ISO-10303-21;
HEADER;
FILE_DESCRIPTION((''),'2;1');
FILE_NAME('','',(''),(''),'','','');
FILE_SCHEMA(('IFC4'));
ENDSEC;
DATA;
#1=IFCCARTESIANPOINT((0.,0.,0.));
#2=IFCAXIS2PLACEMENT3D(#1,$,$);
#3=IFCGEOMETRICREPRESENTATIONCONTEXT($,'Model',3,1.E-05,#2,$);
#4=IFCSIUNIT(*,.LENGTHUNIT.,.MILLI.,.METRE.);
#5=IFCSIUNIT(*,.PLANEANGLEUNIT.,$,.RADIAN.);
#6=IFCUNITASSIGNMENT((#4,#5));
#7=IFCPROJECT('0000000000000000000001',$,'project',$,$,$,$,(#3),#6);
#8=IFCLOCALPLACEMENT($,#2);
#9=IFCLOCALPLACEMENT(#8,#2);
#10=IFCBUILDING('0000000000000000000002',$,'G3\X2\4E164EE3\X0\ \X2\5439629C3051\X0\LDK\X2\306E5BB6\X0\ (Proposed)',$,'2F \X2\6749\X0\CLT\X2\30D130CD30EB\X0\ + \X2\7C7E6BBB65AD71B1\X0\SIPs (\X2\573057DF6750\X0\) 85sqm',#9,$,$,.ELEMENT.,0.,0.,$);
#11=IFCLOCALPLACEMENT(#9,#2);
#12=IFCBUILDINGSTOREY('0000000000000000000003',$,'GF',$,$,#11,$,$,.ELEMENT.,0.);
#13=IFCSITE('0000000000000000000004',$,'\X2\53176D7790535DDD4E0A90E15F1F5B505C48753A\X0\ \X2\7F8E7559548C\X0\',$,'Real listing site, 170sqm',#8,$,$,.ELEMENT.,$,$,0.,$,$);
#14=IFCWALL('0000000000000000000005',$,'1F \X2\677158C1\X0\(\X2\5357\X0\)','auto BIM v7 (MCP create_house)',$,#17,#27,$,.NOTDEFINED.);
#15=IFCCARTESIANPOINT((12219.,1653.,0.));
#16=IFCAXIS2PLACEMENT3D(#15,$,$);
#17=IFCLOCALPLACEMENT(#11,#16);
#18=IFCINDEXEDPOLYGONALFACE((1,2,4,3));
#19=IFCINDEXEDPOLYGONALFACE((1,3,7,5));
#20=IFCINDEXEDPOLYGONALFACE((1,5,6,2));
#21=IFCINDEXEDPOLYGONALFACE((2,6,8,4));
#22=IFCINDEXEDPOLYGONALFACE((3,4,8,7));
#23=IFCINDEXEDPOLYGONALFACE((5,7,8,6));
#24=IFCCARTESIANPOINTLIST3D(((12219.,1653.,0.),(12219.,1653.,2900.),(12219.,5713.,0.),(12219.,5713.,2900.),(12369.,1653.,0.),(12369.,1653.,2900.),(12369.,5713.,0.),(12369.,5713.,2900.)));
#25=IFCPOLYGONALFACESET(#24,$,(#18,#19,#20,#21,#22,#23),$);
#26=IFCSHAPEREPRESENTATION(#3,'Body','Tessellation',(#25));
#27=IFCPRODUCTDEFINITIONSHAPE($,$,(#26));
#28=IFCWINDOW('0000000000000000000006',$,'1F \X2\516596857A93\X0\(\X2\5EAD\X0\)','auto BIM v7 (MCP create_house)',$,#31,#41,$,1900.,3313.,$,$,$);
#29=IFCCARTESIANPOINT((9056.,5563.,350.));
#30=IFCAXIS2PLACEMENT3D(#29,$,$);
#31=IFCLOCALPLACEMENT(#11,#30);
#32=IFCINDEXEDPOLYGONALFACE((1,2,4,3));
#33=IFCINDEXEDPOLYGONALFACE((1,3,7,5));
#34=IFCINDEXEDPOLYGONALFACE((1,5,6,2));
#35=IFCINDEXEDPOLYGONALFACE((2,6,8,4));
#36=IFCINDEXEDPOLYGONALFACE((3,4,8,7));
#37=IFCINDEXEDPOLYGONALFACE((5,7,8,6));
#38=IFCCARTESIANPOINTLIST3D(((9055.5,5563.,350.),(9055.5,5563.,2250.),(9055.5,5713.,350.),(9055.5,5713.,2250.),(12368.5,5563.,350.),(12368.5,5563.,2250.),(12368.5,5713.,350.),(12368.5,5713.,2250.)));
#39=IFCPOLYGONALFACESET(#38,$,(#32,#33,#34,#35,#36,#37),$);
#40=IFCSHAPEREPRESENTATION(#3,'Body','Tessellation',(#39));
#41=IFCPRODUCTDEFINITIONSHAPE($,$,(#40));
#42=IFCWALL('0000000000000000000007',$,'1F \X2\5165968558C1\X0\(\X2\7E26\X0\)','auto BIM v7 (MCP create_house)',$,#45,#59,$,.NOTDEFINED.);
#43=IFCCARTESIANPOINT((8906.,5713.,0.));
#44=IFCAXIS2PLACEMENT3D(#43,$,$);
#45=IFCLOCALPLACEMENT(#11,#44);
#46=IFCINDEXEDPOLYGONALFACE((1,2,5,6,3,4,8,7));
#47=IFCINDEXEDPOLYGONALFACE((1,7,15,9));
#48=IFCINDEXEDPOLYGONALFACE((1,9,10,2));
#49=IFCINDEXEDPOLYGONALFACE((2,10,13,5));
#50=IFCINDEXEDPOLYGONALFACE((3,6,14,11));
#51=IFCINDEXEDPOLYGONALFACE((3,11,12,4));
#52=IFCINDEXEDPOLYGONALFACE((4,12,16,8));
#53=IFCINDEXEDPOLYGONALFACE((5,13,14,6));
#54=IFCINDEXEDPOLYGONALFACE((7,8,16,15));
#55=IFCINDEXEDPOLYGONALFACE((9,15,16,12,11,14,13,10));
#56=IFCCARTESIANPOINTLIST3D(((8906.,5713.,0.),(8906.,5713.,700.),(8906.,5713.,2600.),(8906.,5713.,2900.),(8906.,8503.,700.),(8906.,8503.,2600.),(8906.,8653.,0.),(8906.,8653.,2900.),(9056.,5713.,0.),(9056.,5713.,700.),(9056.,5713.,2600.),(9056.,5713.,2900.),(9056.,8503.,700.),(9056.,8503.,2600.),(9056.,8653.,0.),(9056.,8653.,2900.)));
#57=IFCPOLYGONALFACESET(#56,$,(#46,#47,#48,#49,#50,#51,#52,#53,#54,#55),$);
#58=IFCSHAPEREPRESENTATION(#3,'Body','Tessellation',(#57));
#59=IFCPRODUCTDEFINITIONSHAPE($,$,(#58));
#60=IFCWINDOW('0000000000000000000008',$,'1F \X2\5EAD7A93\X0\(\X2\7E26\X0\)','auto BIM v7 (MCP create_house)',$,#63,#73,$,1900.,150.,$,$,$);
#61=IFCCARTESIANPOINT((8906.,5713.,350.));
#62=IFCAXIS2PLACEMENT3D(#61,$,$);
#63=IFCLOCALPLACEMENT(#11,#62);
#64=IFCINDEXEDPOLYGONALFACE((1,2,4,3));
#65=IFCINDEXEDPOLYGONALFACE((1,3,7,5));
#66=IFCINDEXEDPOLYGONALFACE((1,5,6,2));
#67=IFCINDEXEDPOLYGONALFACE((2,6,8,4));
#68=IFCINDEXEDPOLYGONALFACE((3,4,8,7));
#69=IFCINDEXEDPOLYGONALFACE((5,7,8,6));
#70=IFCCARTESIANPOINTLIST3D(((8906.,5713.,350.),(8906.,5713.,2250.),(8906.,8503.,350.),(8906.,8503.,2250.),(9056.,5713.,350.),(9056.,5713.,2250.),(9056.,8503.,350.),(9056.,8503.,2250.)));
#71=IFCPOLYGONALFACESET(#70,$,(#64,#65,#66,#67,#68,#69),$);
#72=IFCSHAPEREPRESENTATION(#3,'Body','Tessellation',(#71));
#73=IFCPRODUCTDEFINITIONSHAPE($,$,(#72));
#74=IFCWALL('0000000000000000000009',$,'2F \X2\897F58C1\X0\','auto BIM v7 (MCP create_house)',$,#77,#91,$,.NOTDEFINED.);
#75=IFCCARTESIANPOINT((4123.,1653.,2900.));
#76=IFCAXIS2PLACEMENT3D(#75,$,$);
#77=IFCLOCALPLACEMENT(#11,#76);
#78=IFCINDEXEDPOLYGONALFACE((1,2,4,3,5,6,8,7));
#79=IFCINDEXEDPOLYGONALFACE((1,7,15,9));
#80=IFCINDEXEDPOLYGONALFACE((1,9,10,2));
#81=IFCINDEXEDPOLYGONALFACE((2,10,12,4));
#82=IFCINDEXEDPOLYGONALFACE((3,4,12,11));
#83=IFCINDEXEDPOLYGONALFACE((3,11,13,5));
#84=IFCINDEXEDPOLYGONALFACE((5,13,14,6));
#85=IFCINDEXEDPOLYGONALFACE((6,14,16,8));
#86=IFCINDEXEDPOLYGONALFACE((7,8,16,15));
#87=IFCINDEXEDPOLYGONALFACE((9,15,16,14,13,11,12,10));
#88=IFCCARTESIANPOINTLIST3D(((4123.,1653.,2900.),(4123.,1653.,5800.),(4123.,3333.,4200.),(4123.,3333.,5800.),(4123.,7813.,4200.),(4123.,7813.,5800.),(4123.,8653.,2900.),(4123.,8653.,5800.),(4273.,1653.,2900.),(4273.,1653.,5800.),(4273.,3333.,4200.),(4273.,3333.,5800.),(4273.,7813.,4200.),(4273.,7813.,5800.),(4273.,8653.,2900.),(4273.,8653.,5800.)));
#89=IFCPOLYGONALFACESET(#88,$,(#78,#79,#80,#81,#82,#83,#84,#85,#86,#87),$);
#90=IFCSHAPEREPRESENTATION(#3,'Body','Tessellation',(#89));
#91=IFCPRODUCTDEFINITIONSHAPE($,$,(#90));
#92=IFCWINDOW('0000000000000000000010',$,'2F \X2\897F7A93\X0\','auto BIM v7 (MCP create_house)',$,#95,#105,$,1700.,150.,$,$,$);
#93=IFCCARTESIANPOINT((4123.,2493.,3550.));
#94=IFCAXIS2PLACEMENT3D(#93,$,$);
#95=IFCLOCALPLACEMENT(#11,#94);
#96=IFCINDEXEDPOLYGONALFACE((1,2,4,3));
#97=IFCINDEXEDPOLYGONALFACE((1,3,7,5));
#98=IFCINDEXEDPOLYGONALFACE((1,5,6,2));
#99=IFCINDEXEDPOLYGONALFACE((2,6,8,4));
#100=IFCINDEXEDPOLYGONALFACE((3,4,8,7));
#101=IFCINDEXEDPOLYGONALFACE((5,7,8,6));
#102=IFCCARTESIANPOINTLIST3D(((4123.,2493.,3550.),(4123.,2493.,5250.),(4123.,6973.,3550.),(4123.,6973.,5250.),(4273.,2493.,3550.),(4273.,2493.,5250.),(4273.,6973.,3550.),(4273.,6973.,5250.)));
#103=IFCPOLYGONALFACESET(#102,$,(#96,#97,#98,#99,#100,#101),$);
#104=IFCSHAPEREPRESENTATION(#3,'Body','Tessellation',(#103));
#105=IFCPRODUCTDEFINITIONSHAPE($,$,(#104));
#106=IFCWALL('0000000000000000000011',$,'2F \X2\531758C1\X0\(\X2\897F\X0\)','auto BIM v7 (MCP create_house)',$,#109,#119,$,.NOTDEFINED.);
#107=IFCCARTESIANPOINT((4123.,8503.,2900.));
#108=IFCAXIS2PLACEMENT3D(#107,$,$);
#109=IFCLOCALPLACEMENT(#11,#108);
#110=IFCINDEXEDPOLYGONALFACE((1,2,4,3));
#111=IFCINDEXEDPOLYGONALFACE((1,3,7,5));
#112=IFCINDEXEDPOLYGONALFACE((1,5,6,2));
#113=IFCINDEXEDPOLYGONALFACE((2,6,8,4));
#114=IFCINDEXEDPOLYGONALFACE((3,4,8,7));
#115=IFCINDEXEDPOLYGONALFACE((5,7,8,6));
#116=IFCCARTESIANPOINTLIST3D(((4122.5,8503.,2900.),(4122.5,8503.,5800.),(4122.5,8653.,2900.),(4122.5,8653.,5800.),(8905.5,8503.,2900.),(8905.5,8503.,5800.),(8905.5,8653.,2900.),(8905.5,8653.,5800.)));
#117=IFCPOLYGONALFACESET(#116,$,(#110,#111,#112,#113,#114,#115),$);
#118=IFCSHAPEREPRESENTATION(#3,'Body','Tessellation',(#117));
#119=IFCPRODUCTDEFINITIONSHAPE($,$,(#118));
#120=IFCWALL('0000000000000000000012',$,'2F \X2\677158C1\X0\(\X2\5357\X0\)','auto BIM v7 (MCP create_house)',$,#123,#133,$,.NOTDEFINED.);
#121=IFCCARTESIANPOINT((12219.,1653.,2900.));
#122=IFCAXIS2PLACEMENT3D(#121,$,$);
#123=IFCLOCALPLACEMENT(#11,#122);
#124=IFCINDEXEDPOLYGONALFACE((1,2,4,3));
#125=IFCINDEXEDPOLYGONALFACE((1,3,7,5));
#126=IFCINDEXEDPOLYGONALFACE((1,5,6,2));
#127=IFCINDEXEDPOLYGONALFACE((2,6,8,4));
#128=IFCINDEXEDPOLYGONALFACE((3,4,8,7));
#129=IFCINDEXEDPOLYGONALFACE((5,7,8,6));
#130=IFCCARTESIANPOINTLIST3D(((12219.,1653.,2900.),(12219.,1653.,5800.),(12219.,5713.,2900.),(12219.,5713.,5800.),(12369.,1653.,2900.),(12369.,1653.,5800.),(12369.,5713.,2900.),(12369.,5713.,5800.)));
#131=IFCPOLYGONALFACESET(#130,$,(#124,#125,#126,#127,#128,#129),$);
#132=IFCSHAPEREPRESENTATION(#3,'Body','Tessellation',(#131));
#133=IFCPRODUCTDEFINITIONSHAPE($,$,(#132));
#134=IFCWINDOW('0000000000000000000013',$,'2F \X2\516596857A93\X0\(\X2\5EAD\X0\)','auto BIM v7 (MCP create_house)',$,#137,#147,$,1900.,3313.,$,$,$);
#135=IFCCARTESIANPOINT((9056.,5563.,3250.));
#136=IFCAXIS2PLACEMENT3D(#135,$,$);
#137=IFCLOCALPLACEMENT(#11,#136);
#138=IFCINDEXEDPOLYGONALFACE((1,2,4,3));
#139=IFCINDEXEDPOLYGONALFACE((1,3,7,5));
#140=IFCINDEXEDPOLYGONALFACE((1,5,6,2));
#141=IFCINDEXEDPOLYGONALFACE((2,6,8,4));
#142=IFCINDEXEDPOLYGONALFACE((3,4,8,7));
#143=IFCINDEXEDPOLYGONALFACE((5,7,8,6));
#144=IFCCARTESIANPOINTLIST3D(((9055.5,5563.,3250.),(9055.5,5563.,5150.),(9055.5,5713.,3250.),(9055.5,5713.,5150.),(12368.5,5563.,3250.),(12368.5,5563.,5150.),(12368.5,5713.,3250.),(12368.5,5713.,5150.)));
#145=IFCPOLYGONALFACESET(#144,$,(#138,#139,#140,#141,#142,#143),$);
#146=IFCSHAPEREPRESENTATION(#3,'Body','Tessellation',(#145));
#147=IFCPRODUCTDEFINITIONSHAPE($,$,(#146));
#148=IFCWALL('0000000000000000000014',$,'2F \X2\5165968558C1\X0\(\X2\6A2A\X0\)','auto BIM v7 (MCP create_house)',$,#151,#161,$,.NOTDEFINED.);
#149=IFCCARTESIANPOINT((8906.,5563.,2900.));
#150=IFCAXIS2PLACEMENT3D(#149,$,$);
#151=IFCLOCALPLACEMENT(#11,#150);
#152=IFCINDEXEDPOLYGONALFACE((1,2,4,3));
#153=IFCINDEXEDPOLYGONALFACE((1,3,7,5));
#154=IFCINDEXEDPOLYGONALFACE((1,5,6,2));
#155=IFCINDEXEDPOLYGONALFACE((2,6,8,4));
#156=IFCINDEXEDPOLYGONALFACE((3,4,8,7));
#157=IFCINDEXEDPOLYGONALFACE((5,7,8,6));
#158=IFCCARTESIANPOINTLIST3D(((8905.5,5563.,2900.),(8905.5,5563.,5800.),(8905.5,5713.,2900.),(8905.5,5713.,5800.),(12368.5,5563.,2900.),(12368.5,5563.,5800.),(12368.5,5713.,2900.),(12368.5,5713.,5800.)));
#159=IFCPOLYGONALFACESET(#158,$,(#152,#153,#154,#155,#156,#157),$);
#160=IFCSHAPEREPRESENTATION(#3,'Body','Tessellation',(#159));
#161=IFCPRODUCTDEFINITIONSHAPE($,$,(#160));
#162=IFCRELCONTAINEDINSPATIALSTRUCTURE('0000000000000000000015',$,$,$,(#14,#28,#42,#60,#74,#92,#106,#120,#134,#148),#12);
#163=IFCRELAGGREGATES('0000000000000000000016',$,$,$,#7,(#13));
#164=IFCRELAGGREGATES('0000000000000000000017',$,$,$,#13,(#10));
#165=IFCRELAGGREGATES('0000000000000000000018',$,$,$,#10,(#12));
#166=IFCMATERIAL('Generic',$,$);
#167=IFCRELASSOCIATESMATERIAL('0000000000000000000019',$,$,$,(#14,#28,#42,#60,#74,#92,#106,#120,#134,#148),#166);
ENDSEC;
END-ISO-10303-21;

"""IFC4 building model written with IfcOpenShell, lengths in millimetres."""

from ifc_helpers import new_model, si_unit, frame, frame_2d, origin, place, context, project, spatial, rectangle, extrude, material, element, fill, save


model = new_model("IFC4")

# Units and contexts
model_context = context("Model", 3, precision=1e-05, world=origin())
ifc_project = project(units=[si_unit("LENGTHUNIT", "METRE", prefix="MILLI"), si_unit("PLANEANGLEUNIT", "RADIAN")], contexts=[model_context])

# Site, building, storey
site_placement = place(None, origin())
site = spatial("IfcSite", under=ifc_project, at=site_placement, Name="北海道川上郡弟子屈町 美留和", ObjectType="Real listing site, 170sqm", CompositionType="ELEMENT", RefElevation=0.0)
building_placement = place(site_placement, origin())
building = spatial("IfcBuilding", under=site, at=building_placement, Name="G3世代 吹抜けLDKの家 (Proposed)", ObjectType="2F 杉CLTパネル + 籾殻断熱SIPs (地域材) 85sqm", CompositionType="ELEMENT", ElevationOfRefHeight=0.0, ElevationOfTerrain=0.0)
storey_placement = place(building_placement, origin())
storey = spatial("IfcBuildingStorey", under=building, at=storey_placement, Name="GF", CompositionType="ELEMENT", Elevation=0.0)

# Shared definitions
ifc_material = material(Name="Generic")

# Wall, opening, window
wall_1_placement = place(storey_placement, frame((12219.0, 1653.0, 0.0)))
wall_1 = element("IfcWall", 1, at=wall_1_placement, inside=storey, material=ifc_material, Name="1F 東壁(南)", Description="auto BIM v7 (MCP create_house)", PredefinedType="NOTDEFINED", context=model_context, shape_type="SweptSolid", body=[
    extrude(rectangle(XDim=150.0, YDim=4060.0, at=frame_2d((75.0, 2030.0))), frame((12219.0, 1653.0, 0.0)), (0.0, 0.0, 1.0), 2900.0),
])
opening_1_placement = place(storey_placement, frame((9056.0, 5563.0, 350.0)))
opening_1 = element("IfcOpeningElement", 2, at=opening_1_placement, cuts=wall_1, PredefinedType="NOTDEFINED", context=model_context, shape_type="SweptSolid", body=[
    extrude(rectangle(XDim=3313.0, YDim=150.0, at=frame_2d((1656.0, 75.0))), frame((9056.0, 5563.0, 350.0)), (0.0, 0.0, 1.0), 1900.0),
])
window_1_placement = place(storey_placement, frame((9056.0, 5563.0, 350.0)))
window_1 = element("IfcWindow", 3, at=window_1_placement, inside=storey, material=ifc_material, Name="1F 入隅窓(庭)", Description="auto BIM v7 (MCP create_house)", OverallHeight=1900.0, OverallWidth=3313.0, context=model_context, shape_type="SweptSolid", body=[
    extrude(rectangle(XDim=3313.0, YDim=150.0, at=frame_2d((1656.0, 75.0))), frame((9056.0, 5563.0, 350.0)), (0.0, 0.0, 1.0), 1900.0),
])
fill(opening_1, window_1)

# Wall, opening, window
wall_2_placement = place(storey_placement, frame((8906.0, 5713.0, 0.0)))
wall_2 = element("IfcWall", 4, at=wall_2_placement, inside=storey, material=ifc_material, Name="1F 入隅壁(縦)", Description="auto BIM v7 (MCP create_house)", PredefinedType="NOTDEFINED", context=model_context, shape_type="SweptSolid", body=[
    extrude(rectangle(XDim=150.0, YDim=2940.0, at=frame_2d((75.0, 1470.0))), frame((8906.0, 5713.0, 0.0)), (0.0, 0.0, 1.0), 2900.0),
])
opening_2_placement = place(storey_placement, frame((8906.0, 5713.0, 350.0)))
opening_2 = element("IfcOpeningElement", 5, at=opening_2_placement, cuts=wall_2, PredefinedType="NOTDEFINED", context=model_context, shape_type="SweptSolid", body=[
    extrude(rectangle(XDim=150.0, YDim=2790.0, at=frame_2d((75.0, 1395.0))), frame((8906.0, 5713.0, 350.0)), (0.0, 0.0, 1.0), 1900.0),
])
window_2_placement = place(storey_placement, frame((8906.0, 5713.0, 350.0)))
window_2 = element("IfcWindow", 6, at=window_2_placement, inside=storey, material=ifc_material, Name="1F 庭窓(縦)", Description="auto BIM v7 (MCP create_house)", OverallHeight=1900.0, OverallWidth=150.0, context=model_context, shape_type="SweptSolid", body=[
    extrude(rectangle(XDim=150.0, YDim=2790.0, at=frame_2d((75.0, 1395.0))), frame((8906.0, 5713.0, 350.0)), (0.0, 0.0, 1.0), 1900.0),
])
fill(opening_2, window_2)

# Wall, opening, window
wall_3_placement = place(storey_placement, frame((4123.0, 1653.0, 2900.0)))
wall_3 = element("IfcWall", 7, at=wall_3_placement, inside=storey, material=ifc_material, Name="2F 西壁", Description="auto BIM v7 (MCP create_house)", PredefinedType="NOTDEFINED", context=model_context, shape_type="SweptSolid", body=[
    extrude(rectangle(XDim=150.0, YDim=7000.0, at=frame_2d((75.0, 3500.0))), frame((4123.0, 1653.0, 2900.0)), (0.0, 0.0, 1.0), 2900.0),
])
opening_3_placement = place(storey_placement, frame((4123.0, 2493.0, 3550.0)))
opening_3 = element("IfcOpeningElement", 8, at=opening_3_placement, cuts=wall_3, PredefinedType="NOTDEFINED", context=model_context, shape_type="SweptSolid", body=[
    extrude(rectangle(XDim=150.0, YDim=4480.0, at=frame_2d((75.0, 2240.0))), frame((4123.0, 2493.0, 3550.0)), (0.0, 0.0, 1.0), 1700.0),
])
window_3_placement = place(storey_placement, frame((4123.0, 2493.0, 3550.0)))
window_3 = element("IfcWindow", 9, at=window_3_placement, inside=storey, material=ifc_material, Name="2F 西窓", Description="auto BIM v7 (MCP create_house)", OverallHeight=1700.0, OverallWidth=150.0, context=model_context, shape_type="SweptSolid", body=[
    extrude(rectangle(XDim=150.0, YDim=4480.0, at=frame_2d((75.0, 2240.0))), frame((4123.0, 2493.0, 3550.0)), (0.0, 0.0, 1.0), 1700.0),
])
fill(opening_3, window_3)

# Wall
wall_4_placement = place(storey_placement, frame((4123.0, 8503.0, 2900.0)))
element("IfcWall", 10, at=wall_4_placement, inside=storey, material=ifc_material, Name="2F 北壁(西)", Description="auto BIM v7 (MCP create_house)", PredefinedType="NOTDEFINED", context=model_context, shape_type="SweptSolid", body=[
    extrude(rectangle(XDim=4783.0, YDim=150.0, at=frame_2d((2391.0, 75.0))), frame((4123.0, 8503.0, 2900.0)), (0.0, 0.0, 1.0), 2900.0),
])

# Wall, opening, window
wall_5_placement = place(storey_placement, frame((12219.0, 1653.0, 2900.0)))
wall_5 = element("IfcWall", 11, at=wall_5_placement, inside=storey, material=ifc_material, Name="2F 東壁(南)", Description="auto BIM v7 (MCP create_house)", PredefinedType="NOTDEFINED", context=model_context, shape_type="SweptSolid", body=[
    extrude(rectangle(XDim=150.0, YDim=4060.0, at=frame_2d((75.0, 2030.0))), frame((12219.0, 1653.0, 2900.0)), (0.0, 0.0, 1.0), 2900.0),
])
opening_4_placement = place(storey_placement, frame((9056.0, 5563.0, 3250.0)))
opening_4 = element("IfcOpeningElement", 12, at=opening_4_placement, cuts=wall_5, PredefinedType="NOTDEFINED", context=model_context, shape_type="SweptSolid", body=[
    extrude(rectangle(XDim=3313.0, YDim=150.0, at=frame_2d((1656.0, 75.0))), frame((9056.0, 5563.0, 3250.0)), (0.0, 0.0, 1.0), 1900.0),
])
window_4_placement = place(storey_placement, frame((9056.0, 5563.0, 3250.0)))
window_4 = element("IfcWindow", 13, at=window_4_placement, inside=storey, material=ifc_material, Name="2F 入隅窓(庭)", Description="auto BIM v7 (MCP create_house)", OverallHeight=1900.0, OverallWidth=3313.0, context=model_context, shape_type="SweptSolid", body=[
    extrude(rectangle(XDim=3313.0, YDim=150.0, at=frame_2d((1656.0, 75.0))), frame((9056.0, 5563.0, 3250.0)), (0.0, 0.0, 1.0), 1900.0),
])
fill(opening_4, window_4)

# Wall
wall_6_placement = place(storey_placement, frame((8906.0, 5563.0, 2900.0)))
element("IfcWall", 14, at=wall_6_placement, inside=storey, material=ifc_material, Name="2F 入隅壁(横)", Description="auto BIM v7 (MCP create_house)", PredefinedType="NOTDEFINED", context=model_context, shape_type="SweptSolid", body=[
    extrude(rectangle(XDim=3463.0, YDim=150.0, at=frame_2d((1731.0, 75.0))), frame((8906.0, 5563.0, 2900.0)), (0.0, 0.0, 1.0), 2900.0),
])

save(model, "model.ifc")
